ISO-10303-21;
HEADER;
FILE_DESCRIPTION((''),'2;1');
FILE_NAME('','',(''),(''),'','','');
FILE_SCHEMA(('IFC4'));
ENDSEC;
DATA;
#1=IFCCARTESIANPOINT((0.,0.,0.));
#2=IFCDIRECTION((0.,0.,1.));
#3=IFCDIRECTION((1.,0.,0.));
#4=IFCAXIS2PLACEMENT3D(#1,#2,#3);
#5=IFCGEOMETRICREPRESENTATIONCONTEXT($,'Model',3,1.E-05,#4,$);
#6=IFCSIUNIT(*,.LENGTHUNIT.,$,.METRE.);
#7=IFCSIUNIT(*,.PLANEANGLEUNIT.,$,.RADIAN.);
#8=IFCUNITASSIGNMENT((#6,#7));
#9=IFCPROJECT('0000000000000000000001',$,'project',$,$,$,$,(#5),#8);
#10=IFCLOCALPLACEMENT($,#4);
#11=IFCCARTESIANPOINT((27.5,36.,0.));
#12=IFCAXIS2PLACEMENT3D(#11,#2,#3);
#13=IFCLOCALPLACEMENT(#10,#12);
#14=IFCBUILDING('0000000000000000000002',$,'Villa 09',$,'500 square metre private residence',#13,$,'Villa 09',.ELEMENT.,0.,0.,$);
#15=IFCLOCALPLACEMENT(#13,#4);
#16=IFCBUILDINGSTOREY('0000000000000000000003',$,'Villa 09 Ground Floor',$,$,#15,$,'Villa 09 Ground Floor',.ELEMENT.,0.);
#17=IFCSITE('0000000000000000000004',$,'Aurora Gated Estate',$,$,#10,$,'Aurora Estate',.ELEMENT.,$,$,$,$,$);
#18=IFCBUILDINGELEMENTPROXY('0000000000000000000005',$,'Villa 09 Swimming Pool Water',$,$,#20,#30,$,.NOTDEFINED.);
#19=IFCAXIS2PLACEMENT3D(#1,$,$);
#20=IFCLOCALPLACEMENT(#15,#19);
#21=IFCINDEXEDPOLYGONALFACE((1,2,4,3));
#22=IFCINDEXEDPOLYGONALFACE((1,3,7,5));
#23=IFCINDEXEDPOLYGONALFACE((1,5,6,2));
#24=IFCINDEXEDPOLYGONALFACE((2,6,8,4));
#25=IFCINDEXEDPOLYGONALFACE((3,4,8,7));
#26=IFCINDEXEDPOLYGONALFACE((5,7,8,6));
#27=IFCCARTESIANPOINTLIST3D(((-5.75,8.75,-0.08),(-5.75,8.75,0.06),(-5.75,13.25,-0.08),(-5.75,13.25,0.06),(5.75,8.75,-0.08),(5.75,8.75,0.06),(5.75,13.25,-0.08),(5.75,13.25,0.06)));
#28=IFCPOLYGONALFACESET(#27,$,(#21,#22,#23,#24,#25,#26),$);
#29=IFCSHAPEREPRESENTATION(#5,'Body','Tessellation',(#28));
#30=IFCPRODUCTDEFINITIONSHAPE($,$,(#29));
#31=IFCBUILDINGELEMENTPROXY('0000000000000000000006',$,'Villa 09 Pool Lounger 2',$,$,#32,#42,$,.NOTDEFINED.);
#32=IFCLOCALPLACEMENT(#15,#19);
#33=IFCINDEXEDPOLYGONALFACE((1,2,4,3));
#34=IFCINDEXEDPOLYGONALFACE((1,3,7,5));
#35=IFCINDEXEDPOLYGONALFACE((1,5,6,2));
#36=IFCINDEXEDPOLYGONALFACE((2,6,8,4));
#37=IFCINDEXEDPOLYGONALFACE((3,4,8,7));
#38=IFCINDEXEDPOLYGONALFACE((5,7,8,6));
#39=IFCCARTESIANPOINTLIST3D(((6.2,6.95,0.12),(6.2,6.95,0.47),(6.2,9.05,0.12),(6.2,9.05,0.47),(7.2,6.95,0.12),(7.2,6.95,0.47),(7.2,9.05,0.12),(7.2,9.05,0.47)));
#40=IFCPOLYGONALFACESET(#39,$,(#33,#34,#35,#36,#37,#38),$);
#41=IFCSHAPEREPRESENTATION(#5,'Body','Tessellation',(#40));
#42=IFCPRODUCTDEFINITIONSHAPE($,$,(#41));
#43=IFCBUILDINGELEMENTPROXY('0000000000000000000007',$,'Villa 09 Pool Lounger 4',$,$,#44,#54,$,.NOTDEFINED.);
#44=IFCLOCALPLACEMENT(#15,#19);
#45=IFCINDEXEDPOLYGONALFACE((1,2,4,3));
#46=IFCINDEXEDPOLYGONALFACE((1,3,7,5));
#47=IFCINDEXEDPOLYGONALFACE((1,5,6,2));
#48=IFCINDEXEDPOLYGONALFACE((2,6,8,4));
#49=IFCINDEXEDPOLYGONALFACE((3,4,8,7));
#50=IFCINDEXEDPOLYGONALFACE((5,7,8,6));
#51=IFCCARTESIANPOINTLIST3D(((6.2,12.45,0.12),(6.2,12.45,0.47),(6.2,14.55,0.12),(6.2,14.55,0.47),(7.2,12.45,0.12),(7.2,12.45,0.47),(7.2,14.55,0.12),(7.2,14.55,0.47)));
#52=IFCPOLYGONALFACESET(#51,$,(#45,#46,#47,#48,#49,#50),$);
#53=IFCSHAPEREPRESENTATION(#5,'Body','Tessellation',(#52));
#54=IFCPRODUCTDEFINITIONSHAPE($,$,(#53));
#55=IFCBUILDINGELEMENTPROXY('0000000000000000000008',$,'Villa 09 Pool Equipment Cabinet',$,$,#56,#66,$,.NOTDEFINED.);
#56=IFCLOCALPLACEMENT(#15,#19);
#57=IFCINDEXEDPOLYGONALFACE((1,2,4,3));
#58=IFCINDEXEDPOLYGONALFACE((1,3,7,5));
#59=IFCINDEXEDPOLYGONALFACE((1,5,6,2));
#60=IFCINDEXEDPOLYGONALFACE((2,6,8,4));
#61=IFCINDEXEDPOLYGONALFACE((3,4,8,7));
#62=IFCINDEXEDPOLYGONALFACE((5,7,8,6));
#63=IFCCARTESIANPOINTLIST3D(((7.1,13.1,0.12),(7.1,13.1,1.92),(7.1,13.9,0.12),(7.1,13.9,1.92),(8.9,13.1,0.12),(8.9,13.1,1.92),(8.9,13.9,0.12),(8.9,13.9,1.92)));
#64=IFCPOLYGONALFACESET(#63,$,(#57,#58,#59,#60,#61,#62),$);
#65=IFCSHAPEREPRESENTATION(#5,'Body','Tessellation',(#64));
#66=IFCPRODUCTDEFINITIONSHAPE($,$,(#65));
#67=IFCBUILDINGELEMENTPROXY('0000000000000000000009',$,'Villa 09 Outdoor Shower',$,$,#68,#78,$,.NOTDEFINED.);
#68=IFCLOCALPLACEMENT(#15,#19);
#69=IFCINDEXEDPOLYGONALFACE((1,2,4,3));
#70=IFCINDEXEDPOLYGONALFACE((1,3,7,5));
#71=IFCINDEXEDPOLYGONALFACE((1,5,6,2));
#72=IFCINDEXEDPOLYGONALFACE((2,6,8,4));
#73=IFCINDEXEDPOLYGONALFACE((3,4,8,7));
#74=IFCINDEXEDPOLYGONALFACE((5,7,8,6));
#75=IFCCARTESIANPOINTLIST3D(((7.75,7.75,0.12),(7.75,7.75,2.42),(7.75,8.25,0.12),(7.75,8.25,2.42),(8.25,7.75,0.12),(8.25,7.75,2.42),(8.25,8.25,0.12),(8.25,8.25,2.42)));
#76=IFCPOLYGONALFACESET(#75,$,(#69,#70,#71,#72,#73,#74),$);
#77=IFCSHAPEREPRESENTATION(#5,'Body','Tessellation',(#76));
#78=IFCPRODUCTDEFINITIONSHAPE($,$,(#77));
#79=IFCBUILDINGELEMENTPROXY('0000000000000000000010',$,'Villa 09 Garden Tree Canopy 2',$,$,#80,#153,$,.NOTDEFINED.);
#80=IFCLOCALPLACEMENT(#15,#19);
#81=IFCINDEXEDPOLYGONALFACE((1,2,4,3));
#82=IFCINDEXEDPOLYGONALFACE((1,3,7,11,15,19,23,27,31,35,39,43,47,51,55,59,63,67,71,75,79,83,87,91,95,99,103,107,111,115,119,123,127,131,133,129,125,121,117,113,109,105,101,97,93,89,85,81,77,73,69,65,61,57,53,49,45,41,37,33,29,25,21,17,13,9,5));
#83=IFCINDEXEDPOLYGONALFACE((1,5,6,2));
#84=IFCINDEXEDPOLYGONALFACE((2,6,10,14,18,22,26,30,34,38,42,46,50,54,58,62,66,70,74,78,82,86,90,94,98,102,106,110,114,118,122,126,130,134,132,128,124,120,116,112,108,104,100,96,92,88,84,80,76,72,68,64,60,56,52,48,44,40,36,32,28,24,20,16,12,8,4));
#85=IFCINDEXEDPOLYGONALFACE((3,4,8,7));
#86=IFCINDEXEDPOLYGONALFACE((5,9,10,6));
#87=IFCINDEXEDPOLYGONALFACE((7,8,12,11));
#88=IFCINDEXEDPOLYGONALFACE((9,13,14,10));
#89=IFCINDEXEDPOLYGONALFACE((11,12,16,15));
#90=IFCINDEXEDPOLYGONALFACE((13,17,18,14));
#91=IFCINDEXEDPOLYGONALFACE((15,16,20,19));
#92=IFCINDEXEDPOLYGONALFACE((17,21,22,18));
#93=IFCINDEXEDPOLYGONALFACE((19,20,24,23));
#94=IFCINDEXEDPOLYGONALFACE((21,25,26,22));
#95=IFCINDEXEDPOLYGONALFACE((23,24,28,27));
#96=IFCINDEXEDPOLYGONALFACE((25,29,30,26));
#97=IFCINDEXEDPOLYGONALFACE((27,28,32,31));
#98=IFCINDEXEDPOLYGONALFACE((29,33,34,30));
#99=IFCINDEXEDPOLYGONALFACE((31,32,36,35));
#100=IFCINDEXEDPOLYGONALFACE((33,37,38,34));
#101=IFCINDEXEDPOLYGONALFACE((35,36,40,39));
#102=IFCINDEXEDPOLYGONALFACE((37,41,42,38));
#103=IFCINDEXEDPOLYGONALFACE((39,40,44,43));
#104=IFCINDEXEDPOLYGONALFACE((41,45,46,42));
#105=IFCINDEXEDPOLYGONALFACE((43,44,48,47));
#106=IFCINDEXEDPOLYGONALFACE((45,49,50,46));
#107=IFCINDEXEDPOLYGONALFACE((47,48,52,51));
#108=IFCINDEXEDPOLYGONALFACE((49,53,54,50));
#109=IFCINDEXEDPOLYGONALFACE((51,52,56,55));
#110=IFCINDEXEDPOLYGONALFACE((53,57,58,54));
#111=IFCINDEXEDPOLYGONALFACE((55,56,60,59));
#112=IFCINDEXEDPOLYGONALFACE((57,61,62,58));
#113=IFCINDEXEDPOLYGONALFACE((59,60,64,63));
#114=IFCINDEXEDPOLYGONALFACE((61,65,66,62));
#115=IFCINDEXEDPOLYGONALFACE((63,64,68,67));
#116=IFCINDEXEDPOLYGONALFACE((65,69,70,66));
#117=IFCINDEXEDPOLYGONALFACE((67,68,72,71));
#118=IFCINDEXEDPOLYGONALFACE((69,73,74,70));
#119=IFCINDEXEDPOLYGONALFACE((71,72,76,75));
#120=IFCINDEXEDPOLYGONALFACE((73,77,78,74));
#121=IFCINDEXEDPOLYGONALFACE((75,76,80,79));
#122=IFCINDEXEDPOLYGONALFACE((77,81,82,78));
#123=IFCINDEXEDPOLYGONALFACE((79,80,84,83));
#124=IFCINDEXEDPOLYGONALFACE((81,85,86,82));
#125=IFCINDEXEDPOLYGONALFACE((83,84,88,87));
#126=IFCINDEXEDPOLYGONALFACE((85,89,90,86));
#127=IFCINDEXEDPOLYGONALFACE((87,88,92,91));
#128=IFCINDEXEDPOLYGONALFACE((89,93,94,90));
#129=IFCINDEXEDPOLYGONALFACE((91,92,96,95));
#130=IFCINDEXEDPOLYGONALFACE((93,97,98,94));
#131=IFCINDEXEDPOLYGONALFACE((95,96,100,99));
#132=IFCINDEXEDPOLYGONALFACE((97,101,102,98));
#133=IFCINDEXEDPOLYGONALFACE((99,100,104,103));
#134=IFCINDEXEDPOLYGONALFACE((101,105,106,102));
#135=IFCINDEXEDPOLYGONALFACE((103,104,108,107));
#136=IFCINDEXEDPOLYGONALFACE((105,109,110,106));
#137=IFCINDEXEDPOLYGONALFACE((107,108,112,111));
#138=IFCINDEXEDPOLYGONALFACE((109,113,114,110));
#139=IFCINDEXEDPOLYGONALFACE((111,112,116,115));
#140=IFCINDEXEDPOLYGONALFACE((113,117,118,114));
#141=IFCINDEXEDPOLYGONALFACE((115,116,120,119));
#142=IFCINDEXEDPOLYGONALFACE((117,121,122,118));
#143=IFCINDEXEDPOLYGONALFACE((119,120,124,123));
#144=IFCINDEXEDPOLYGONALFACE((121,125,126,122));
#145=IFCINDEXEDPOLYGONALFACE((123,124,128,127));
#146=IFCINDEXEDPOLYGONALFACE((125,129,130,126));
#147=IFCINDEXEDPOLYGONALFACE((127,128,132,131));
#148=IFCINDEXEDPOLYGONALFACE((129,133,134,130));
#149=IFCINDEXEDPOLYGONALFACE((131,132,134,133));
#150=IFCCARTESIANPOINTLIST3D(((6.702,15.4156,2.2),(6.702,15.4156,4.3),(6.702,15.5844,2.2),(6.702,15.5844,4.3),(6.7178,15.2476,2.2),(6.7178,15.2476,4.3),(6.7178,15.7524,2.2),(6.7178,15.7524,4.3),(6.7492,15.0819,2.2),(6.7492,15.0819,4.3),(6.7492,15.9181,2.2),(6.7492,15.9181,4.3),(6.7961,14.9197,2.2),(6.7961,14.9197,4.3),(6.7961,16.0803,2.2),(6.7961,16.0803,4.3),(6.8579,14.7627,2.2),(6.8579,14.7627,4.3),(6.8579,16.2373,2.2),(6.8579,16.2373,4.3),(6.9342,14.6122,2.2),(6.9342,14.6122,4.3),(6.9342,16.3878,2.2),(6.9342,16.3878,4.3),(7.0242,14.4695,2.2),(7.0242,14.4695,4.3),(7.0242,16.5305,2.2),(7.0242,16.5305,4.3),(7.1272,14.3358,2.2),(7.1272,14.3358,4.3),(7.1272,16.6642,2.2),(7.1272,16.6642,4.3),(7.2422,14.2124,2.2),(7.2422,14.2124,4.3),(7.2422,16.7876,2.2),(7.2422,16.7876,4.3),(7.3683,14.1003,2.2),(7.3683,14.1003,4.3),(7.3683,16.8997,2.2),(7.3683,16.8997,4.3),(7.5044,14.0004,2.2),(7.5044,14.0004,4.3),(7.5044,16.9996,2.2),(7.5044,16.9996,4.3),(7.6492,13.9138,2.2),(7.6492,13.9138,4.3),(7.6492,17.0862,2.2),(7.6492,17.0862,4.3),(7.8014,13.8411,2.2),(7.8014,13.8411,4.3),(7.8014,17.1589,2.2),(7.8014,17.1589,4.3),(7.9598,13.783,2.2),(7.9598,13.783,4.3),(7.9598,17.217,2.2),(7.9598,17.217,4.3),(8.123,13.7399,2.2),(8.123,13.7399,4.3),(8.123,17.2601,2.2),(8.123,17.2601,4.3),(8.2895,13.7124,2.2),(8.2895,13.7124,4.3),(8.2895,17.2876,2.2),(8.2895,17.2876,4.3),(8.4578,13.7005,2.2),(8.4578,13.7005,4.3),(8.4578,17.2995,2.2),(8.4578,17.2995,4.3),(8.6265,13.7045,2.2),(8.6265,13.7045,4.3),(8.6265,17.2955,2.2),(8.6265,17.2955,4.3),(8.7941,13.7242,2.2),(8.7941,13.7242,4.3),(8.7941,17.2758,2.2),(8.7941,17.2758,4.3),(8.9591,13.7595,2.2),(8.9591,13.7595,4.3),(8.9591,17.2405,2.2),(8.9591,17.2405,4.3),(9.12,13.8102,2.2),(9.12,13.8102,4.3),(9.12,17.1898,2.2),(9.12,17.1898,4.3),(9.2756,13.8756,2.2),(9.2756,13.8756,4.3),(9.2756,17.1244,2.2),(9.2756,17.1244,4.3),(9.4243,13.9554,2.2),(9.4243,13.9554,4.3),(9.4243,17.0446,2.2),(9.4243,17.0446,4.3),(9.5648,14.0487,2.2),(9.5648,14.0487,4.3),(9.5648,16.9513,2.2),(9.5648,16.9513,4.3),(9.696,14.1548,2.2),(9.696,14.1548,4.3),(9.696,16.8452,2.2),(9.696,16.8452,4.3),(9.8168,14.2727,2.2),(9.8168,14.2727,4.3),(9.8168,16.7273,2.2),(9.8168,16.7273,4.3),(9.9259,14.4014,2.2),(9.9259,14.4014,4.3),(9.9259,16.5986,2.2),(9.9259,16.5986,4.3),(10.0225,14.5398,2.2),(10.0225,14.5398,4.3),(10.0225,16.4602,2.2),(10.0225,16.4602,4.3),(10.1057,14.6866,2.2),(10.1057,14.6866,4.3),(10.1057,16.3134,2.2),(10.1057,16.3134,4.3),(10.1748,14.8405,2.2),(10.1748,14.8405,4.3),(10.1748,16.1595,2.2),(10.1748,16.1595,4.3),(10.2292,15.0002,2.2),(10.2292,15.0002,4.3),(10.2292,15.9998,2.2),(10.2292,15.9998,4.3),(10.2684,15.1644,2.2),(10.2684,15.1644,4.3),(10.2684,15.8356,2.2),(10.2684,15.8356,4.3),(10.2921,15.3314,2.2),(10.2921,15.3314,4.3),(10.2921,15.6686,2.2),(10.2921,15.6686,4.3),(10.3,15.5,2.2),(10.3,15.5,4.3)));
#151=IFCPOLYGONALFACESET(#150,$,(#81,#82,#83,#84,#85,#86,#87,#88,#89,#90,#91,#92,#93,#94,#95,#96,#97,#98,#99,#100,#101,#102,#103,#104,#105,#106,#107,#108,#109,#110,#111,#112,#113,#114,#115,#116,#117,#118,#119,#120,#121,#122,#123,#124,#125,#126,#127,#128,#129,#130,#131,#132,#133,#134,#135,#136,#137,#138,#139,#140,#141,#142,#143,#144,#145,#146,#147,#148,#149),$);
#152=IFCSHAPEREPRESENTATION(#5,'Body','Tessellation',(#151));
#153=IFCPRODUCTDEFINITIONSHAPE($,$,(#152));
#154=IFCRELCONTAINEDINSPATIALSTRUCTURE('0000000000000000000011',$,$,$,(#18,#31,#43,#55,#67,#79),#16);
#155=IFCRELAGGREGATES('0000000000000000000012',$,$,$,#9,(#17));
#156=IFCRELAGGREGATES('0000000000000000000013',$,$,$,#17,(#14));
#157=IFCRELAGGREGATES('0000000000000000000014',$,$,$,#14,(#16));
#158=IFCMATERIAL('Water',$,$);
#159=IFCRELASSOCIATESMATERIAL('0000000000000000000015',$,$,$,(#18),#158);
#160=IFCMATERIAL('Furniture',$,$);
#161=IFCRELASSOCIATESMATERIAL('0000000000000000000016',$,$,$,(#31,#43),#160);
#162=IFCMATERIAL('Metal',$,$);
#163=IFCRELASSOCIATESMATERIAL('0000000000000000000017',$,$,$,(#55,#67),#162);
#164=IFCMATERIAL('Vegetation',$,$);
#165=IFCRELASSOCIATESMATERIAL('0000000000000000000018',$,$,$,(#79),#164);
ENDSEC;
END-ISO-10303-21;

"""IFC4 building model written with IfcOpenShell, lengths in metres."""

from ifc_helpers import new_model, si_unit, frame, origin_with_axes, origin_2d_with_axis, place, context, project, spatial, rectangle, circle, extrude, material, element, save


model = new_model("IFC4")

# Units and contexts
model_context = context("Model", 3, precision=1e-05, world=origin_with_axes())
ifc_project = project(units=[si_unit("LENGTHUNIT", "METRE"), si_unit("PLANEANGLEUNIT", "RADIAN")], contexts=[model_context])

# Site, building, storey
site_placement = place(None, origin_with_axes())
site = spatial("IfcSite", under=ifc_project, at=site_placement, Name="Aurora Gated Estate", LongName="Aurora Estate", CompositionType="ELEMENT")
building_placement = place(site_placement, frame((27.5, 36.0, 0.0), z_axis=(0.0, 0.0, 1.0), x_axis=(1.0, 0.0, 0.0)))
building = spatial("IfcBuilding", under=site, at=building_placement, Name="Villa 09", ObjectType="500 square metre private residence", LongName="Villa 09", CompositionType="ELEMENT", ElevationOfRefHeight=0.0, ElevationOfTerrain=0.0)
storey_placement = place(building_placement, origin_with_axes())
storey = spatial("IfcBuildingStorey", under=building, at=storey_placement, Name="Villa 09 Ground Floor", LongName="Villa 09 Ground Floor", CompositionType="ELEMENT", Elevation=0.0)

# Building element proxies
ifc_material_1 = material(Name="Furniture")
ifc_material_2 = material(Name="Metal")
ifc_material_3 = material(Name="Water")
proxy_1_placement = place(storey_placement, frame((0.0, 11.0, -0.08), z_axis=(0.0, 0.0, 1.0), x_axis=(1.0, 0.0, 0.0)))
element("IfcBuildingElementProxy", 1, at=proxy_1_placement, inside=storey, material=ifc_material_3, Name="Villa 09 Swimming Pool Water", PredefinedType="NOTDEFINED", context=model_context, shape_type="SweptSolid", body=[
    extrude(rectangle(XDim=11.5, YDim=4.5, at=origin_2d_with_axis()), origin_with_axes(), (0.0, 0.0, 1.0), 0.14),
])
for number, where, z_axis, x_axis, name in (
    (2, (6.7, 8.0, 0.12), (0.0, 0.0, 1.0), (1.0, 0.0, 0.0), "Villa 09 Pool Lounger 2"),
    (3, (6.7, 13.5, 0.12), (0.0, 0.0, 1.0), (1.0, 0.0, 0.0), "Villa 09 Pool Lounger 4"),
):
    element("IfcBuildingElementProxy", number, at=place(storey_placement, frame(where, z_axis=z_axis, x_axis=x_axis)), inside=storey, material=ifc_material_1, Name=name, PredefinedType="NOTDEFINED", context=model_context, shape_type="SweptSolid", body=[
        extrude(rectangle(XDim=1.0, YDim=2.1, at=origin_2d_with_axis()), origin_with_axes(), (0.0, 0.0, 1.0), 0.35),
    ])
proxy_2_placement = place(storey_placement, frame((8.0, 13.5, 0.12), z_axis=(0.0, 0.0, 1.0), x_axis=(1.0, 0.0, 0.0)))
element("IfcBuildingElementProxy", 4, at=proxy_2_placement, inside=storey, material=ifc_material_2, Name="Villa 09 Pool Equipment Cabinet", PredefinedType="NOTDEFINED", context=model_context, shape_type="SweptSolid", body=[
    extrude(rectangle(XDim=1.8, YDim=0.8, at=origin_2d_with_axis()), origin_with_axes(), (0.0, 0.0, 1.0), 1.8),
])
proxy_3_placement = place(storey_placement, frame((8.0, 8.0, 0.12), z_axis=(0.0, 0.0, 1.0), x_axis=(1.0, 0.0, 0.0)))
element("IfcBuildingElementProxy", 5, at=proxy_3_placement, inside=storey, material=ifc_material_2, Name="Villa 09 Outdoor Shower", PredefinedType="NOTDEFINED", context=model_context, shape_type="SweptSolid", body=[
    extrude(rectangle(XDim=0.5, YDim=0.5, at=origin_2d_with_axis()), origin_with_axes(), (0.0, 0.0, 1.0), 2.3),
])
ifc_material_4 = material(Name="Vegetation")
proxy_4_placement = place(storey_placement, frame((8.5, 15.5, 2.2), z_axis=(0.0, 0.0, 1.0), x_axis=(1.0, 0.0, 0.0)))
element("IfcBuildingElementProxy", 6, at=proxy_4_placement, inside=storey, material=ifc_material_4, Name="Villa 09 Garden Tree Canopy 2", PredefinedType="NOTDEFINED", context=model_context, shape_type="SweptSolid", body=[
    extrude(circle(Radius=1.8, at=origin_2d_with_axis()), origin_with_axes(), (0.0, 0.0, 1.0), 2.1),
])

save(model, "model.ifc")
